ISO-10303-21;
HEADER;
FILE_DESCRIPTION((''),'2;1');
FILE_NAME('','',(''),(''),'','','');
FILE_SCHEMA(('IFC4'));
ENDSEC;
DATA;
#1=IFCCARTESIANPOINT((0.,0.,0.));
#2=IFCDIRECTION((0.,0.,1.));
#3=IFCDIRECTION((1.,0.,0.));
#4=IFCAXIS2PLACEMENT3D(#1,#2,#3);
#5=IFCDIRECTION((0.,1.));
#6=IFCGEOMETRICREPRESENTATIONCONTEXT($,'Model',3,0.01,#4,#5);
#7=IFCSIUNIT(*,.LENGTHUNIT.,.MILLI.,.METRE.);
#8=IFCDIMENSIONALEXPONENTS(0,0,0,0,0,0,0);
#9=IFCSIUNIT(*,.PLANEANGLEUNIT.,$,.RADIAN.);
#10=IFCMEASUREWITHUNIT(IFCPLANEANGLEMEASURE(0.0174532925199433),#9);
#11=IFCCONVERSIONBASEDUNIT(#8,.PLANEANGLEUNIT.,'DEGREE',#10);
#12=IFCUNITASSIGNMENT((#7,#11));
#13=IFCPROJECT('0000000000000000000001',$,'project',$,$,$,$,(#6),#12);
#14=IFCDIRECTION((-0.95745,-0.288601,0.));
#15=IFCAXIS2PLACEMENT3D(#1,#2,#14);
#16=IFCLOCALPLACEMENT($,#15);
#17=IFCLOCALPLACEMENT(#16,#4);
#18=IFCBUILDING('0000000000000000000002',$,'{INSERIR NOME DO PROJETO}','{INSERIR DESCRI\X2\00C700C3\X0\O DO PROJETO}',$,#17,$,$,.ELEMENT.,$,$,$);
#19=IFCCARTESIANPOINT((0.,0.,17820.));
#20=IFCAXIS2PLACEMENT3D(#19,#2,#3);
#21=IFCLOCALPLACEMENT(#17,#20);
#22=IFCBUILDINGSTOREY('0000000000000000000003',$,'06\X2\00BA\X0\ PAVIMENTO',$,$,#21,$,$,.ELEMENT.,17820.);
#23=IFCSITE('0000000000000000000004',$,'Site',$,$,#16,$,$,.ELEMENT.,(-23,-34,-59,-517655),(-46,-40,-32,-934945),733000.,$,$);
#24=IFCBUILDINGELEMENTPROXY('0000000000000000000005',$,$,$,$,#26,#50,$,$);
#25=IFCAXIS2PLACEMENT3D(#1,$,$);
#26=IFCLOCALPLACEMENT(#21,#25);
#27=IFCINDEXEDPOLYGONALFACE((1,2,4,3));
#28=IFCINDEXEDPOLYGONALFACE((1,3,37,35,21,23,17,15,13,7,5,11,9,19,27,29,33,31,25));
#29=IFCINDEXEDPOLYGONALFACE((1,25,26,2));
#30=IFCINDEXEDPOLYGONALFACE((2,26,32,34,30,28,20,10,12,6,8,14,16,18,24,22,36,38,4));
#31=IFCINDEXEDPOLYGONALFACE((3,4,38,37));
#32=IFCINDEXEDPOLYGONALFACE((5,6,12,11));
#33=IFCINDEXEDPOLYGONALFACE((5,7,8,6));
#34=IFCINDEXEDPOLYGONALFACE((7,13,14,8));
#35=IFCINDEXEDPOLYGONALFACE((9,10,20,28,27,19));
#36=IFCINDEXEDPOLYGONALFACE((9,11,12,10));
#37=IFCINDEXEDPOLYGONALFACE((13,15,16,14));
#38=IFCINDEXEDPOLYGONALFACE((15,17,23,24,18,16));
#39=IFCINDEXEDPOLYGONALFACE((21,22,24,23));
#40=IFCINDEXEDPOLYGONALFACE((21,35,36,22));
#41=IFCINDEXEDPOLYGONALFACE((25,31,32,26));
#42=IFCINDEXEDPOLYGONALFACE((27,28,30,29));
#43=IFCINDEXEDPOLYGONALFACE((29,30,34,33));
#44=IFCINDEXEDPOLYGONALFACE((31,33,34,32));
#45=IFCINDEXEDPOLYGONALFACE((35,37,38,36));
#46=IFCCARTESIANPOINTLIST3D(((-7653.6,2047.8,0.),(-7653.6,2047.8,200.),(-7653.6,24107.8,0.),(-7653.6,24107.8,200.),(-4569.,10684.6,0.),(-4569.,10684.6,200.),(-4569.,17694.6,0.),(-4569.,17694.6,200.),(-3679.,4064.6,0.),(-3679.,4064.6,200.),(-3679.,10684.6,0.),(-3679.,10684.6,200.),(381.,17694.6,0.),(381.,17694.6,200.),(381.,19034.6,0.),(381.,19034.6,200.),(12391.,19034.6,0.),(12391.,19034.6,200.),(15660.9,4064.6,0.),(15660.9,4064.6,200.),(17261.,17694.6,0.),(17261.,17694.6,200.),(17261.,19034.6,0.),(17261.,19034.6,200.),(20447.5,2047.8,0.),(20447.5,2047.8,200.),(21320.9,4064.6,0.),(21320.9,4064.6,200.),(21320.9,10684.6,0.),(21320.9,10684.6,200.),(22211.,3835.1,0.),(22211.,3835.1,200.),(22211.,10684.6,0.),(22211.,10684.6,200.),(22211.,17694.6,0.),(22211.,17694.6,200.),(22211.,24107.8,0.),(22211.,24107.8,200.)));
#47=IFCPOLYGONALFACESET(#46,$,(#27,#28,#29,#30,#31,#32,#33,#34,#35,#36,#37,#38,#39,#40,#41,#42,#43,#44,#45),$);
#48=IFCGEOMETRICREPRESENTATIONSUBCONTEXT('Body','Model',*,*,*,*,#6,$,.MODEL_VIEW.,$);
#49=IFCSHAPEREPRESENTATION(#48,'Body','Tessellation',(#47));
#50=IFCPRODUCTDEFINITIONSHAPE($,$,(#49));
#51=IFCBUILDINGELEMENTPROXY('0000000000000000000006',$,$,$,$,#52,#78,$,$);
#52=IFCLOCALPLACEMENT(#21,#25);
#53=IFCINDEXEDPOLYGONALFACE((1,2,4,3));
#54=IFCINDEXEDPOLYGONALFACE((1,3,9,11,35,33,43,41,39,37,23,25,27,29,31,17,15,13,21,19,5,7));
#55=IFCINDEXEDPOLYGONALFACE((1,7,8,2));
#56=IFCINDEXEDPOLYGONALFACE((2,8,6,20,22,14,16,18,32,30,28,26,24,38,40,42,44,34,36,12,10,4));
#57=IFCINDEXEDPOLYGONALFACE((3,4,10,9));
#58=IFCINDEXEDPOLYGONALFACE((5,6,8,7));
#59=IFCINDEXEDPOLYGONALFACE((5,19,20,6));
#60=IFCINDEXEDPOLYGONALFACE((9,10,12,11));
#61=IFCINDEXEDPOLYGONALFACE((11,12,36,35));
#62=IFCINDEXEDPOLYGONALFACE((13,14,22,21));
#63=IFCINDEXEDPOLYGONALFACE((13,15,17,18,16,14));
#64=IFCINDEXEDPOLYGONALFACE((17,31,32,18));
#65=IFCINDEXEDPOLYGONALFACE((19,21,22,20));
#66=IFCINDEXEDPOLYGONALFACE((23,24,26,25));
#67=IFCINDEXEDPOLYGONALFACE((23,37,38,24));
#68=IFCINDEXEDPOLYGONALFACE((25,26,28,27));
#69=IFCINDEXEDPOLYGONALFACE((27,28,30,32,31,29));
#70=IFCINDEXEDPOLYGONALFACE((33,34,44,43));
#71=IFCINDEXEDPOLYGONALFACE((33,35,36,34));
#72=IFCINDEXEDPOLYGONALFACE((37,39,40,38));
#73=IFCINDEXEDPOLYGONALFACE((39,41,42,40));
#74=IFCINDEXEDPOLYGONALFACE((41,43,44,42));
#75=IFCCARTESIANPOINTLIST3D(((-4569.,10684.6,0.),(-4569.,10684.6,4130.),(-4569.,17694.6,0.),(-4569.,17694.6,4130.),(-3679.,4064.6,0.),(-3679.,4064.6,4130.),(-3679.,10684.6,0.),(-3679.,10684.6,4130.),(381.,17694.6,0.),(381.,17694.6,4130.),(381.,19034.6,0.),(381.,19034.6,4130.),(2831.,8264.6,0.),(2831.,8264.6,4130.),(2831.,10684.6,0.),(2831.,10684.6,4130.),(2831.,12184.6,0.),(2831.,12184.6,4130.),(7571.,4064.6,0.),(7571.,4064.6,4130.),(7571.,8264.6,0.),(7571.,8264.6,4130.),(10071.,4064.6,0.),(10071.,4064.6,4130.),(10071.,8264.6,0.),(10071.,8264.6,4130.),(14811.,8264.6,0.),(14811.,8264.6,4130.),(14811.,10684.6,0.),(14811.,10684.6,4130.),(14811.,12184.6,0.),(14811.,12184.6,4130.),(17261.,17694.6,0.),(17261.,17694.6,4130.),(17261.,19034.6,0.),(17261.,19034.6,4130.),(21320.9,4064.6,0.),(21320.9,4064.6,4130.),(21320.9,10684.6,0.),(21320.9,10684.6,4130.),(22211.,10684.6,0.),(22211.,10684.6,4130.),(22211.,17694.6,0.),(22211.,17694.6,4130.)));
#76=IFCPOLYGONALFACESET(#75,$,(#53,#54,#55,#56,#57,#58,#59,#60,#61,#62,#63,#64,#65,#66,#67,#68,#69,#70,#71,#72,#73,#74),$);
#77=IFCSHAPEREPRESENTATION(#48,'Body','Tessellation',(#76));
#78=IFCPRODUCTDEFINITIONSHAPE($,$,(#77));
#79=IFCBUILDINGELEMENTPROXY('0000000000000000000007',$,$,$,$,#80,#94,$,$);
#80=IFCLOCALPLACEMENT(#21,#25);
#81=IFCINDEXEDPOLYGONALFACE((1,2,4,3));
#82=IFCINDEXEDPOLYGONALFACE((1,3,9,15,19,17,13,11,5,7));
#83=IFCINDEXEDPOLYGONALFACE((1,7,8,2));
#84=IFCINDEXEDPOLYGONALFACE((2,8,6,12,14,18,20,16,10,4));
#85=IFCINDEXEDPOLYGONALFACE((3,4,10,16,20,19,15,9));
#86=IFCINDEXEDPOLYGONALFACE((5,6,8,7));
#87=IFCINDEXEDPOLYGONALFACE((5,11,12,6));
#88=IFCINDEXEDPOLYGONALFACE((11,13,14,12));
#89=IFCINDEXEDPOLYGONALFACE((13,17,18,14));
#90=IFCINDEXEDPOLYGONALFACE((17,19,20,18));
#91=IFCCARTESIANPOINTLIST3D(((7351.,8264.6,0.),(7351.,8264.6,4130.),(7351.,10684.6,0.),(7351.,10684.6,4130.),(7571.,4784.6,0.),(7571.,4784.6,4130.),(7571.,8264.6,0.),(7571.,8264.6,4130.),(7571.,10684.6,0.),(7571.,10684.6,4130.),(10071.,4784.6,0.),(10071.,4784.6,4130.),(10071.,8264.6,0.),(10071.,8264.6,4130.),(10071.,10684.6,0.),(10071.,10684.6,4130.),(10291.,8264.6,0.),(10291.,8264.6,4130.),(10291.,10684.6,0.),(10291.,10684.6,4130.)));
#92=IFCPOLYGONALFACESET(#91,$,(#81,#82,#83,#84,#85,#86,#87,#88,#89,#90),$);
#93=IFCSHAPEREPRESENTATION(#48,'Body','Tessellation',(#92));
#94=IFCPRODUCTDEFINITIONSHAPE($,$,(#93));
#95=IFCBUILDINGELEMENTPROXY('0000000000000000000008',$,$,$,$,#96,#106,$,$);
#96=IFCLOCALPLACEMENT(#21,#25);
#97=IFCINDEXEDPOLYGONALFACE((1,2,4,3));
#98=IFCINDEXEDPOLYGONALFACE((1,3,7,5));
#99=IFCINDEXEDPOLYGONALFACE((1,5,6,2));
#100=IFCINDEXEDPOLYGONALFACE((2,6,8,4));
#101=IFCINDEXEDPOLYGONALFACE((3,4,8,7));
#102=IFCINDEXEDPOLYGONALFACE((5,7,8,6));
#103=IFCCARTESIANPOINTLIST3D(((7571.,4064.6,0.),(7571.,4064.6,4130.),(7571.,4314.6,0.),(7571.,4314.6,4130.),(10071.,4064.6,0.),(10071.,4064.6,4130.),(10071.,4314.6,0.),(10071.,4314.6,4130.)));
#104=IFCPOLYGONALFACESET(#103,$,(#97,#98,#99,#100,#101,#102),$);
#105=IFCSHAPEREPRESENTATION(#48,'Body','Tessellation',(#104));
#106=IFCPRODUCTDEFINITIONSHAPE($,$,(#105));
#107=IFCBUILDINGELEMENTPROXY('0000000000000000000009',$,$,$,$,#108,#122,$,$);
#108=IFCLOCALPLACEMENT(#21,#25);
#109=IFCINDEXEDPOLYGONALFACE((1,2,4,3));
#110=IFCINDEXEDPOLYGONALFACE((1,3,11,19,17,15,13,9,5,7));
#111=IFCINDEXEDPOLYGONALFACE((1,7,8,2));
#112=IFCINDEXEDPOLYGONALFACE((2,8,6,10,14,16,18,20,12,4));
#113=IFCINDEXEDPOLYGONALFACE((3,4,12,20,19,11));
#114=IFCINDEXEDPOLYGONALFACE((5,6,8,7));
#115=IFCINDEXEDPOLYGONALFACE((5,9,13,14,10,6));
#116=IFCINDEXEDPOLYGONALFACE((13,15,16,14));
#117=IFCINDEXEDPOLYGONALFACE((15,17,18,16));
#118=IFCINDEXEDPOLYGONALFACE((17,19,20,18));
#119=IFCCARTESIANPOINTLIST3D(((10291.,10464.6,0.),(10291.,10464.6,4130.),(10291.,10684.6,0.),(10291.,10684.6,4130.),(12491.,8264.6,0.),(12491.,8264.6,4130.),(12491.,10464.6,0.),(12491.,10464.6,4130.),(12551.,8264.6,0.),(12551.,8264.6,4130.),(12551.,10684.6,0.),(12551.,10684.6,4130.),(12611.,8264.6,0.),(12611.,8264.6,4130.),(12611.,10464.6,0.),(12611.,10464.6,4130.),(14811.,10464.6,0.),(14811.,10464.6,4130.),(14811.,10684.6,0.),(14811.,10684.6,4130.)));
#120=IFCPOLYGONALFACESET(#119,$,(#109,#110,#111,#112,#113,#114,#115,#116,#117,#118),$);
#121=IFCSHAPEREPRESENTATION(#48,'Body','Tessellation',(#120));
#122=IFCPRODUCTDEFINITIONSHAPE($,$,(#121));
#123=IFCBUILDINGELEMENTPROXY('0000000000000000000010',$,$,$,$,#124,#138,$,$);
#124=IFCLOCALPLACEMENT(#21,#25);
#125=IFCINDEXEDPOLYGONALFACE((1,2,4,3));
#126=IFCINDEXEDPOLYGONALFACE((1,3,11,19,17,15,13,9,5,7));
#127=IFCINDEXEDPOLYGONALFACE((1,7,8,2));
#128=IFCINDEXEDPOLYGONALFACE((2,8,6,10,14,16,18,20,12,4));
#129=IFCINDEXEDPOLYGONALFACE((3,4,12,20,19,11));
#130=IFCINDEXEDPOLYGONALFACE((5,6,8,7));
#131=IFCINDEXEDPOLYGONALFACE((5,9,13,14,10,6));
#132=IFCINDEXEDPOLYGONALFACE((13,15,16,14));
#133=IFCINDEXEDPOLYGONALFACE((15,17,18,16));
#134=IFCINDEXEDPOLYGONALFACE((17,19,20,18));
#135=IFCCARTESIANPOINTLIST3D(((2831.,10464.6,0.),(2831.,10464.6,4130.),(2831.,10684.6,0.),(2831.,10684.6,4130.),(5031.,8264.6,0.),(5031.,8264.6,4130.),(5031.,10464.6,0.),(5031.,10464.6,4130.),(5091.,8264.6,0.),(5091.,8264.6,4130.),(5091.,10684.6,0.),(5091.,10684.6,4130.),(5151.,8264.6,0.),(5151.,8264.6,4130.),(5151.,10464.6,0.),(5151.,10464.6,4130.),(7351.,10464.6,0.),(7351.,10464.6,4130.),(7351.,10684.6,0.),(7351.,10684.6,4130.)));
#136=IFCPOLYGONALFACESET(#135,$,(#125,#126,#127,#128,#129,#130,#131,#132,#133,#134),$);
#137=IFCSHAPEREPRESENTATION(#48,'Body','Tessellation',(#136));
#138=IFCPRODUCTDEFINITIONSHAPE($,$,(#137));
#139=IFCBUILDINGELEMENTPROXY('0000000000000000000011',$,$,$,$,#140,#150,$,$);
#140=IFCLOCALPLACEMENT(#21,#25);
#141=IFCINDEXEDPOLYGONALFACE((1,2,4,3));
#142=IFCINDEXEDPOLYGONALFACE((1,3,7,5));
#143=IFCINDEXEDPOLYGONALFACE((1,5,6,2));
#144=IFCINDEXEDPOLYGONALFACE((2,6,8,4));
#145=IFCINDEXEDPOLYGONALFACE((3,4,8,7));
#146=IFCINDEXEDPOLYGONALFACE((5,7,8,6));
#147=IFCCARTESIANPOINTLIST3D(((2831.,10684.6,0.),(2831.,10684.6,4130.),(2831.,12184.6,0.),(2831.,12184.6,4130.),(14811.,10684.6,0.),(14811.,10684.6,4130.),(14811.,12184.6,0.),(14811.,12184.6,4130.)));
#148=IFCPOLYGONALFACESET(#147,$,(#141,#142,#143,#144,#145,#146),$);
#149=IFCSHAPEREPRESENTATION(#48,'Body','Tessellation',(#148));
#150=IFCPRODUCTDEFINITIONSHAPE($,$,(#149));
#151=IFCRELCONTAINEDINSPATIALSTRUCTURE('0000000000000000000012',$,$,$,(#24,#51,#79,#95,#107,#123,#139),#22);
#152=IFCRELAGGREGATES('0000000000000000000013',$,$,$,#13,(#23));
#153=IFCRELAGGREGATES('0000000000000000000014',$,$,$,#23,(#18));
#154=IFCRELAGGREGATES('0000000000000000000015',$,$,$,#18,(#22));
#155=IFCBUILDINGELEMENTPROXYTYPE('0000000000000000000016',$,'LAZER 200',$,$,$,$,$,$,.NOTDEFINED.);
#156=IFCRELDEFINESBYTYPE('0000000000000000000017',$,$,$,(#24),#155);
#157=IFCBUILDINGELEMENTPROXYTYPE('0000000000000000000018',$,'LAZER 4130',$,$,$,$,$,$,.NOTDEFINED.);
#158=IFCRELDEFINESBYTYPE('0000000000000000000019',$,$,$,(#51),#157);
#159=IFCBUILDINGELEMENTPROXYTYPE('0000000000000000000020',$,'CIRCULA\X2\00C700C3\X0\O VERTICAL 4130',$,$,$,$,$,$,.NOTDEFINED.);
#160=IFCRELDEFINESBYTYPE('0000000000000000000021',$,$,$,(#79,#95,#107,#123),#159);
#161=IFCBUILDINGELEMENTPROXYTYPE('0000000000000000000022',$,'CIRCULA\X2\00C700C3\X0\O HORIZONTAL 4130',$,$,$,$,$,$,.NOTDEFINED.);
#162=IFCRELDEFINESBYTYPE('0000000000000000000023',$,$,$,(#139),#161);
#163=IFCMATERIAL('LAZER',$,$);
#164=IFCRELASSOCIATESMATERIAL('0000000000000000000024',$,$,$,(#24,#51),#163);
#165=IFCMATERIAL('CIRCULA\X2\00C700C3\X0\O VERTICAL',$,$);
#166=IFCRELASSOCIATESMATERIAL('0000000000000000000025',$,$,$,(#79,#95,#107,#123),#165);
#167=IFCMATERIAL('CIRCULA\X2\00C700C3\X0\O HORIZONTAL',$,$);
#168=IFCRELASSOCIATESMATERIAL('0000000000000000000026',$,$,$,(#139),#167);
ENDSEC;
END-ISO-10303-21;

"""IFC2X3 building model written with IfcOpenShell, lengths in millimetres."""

from ifc_helpers import new_model, entity, si_unit, converted_unit, direction, frame, origin_with_axes, place, context, subcontext, project, spatial, polyline, outline, extrude, material, type_object, element, save


model = new_model("IFC2X3")

# Units and contexts
model_context = context("Model", 3, precision=0.01, world=origin_with_axes(), true_north=direction((0.0, 1.0)))
body_context = subcontext(model_context, "Body", "Model", "MODEL_VIEW")
ifc_project = project(units=[si_unit("LENGTHUNIT", "METRE", prefix="MILLI"), converted_unit("PLANEANGLEUNIT", "DEGREE", entity("IfcPlaneAngleMeasure", 0.0174532925199433), si_unit("PLANEANGLEUNIT", "RADIAN"), dimensions=[0, 0, 0, 0, 0, 0, 0])], contexts=[model_context])

# Site, building, storey
site_placement = place(None, frame((0.0, 0.0, 0.0), z_axis=(0.0, 0.0, 1.0), x_axis=(-0.95745, -0.288601, 0.0)))
site = spatial("IfcSite", under=ifc_project, at=site_placement, Name="Site", CompositionType="ELEMENT", RefLatitude=(-23, -34, -59, -517655), RefLongitude=(-46, -40, -32, -934945), RefElevation=733000.0)
building_placement = place(site_placement, origin_with_axes())
building = spatial("IfcBuilding", under=site, at=building_placement, Name="{INSERIR NOME DO PROJETO}", Description="{INSERIR DESCRIÇÃO DO PROJETO}", CompositionType="ELEMENT")
storey_placement = place(building_placement, frame((0.0, 0.0, 17820.0), z_axis=(0.0, 0.0, 1.0), x_axis=(1.0, 0.0, 0.0)))
storey = spatial("IfcBuildingStorey", under=building, at=storey_placement, Name="06º PAVIMENTO", CompositionType="ELEMENT", Elevation=17820.0)

# Building element proxies
ifc_material_1 = material(Name="LAZER")
building_element_proxy_type_1 = type_object("IfcBuildingElementProxyType", Name="LAZER 200", PredefinedType="NOTDEFINED")
proxy_1_placement = place(storey_placement, frame((-7653.6, 24107.8, 0.0), z_axis=(0.0, 0.0, 1.0), x_axis=(1.0, 0.0, 0.0)))
element("IfcBuildingElementProxy", 1, at=proxy_1_placement, inside=storey, type_object=building_element_proxy_type_1, material=ifc_material_1, context=body_context, shape_type="SweptSolid", body=[
    extrude(outline(polyline([(0.0, 0.0), (0.0, -22060.0), (28101.1, -22060.0), (29864.6, -20272.6), (29864.6, -13423.2), (28974.6, -13423.2), (28974.6, -20043.2), (23314.5, -20043.2), (3974.6, -20043.2), (3974.6, -13423.2), (3084.6, -13423.2), (3084.6, -6413.2), (8034.6, -6413.2), (8034.6, -5073.2), (20044.6, -5073.2), (24914.6, -5073.2), (24914.6, -6413.2), (29864.6, -6413.2), (29864.6, 0.0), (0.0, 0.0)])), origin_with_axes(), (0.0, 0.0, 1.0), 200.0),
])
building_element_proxy_type_2 = type_object("IfcBuildingElementProxyType", Name="LAZER 4130", PredefinedType="NOTDEFINED")
proxy_2_placement = place(storey_placement, frame((-4569.0, 10684.6, 0.0), z_axis=(0.0, 0.0, 1.0), x_axis=(1.0, 0.0, 0.0)))
element("IfcBuildingElementProxy", 2, at=proxy_2_placement, inside=storey, type_object=building_element_proxy_type_2, material=ifc_material_1, context=body_context, shape_type="SweptSolid", body=[
    extrude(outline(polyline([(0.0, 0.0), (890.0, 0.0), (890.0, -6620.0), (12140.0, -6620.0), (12140.0, -2420.0), (7400.0, -2420.0), (7400.0, 0.0), (7400.0, 1500.0), (19380.0, 1500.0), (19380.0, 0.0), (19380.0, -2420.0), (14640.0, -2420.0), (14640.0, -6620.0), (25890.0, -6620.0), (25890.0, 0.0), (26780.0, 0.0), (26780.0, 7010.0), (21830.0, 7010.0), (21830.0, 8350.0), (4950.0, 8350.0), (4950.0, 7010.0), (0.0, 7010.0), (0.0, 0.0)])), origin_with_axes(), (0.0, 0.0, 1.0), 4130.0),
])
ifc_material_2 = material(Name="CIRCULAÇÃO VERTICAL")
building_element_proxy_type_3 = type_object("IfcBuildingElementProxyType", Name="CIRCULAÇÃO VERTICAL 4130", PredefinedType="NOTDEFINED")
proxy_3_placement = place(storey_placement, frame((7351.0, 10684.6, 0.0), z_axis=(0.0, 0.0, 1.0), x_axis=(1.0, 0.0, 0.0)))
element("IfcBuildingElementProxy", 3, at=proxy_3_placement, inside=storey, type_object=building_element_proxy_type_3, material=ifc_material_2, context=body_context, shape_type="SweptSolid", body=[
    extrude(outline(polyline([(0.0, 0.0), (0.0, -2420.0), (220.0, -2420.0), (220.0, -5900.0), (2720.0, -5900.0), (2720.0, -2420.0), (2940.0, -2420.0), (2940.0, 0.0), (2720.0, 0.0), (220.0, 0.0), (0.0, 0.0)])), origin_with_axes(), (0.0, 0.0, 1.0), 4130.0),
])
proxy_4_placement = place(storey_placement, frame((7571.0, 4064.6, 0.0), z_axis=(0.0, 0.0, 1.0), x_axis=(1.0, 0.0, 0.0)))
element("IfcBuildingElementProxy", 4, at=proxy_4_placement, inside=storey, type_object=building_element_proxy_type_3, material=ifc_material_2, context=body_context, shape_type="SweptSolid", body=[
    extrude(outline(polyline([(0.0, 0.0), (2500.0, 0.0), (2500.0, 250.0), (0.0, 250.0), (0.0, 0.0)])), origin_with_axes(), (0.0, 0.0, 1.0), 4130.0),
])
proxy_5_placement = place(storey_placement, frame((10291.0, 10684.6, 0.0), z_axis=(0.0, 0.0, 1.0), x_axis=(1.0, 0.0, 0.0)))
element("IfcBuildingElementProxy", 5, at=proxy_5_placement, inside=storey, type_object=building_element_proxy_type_3, material=ifc_material_2, context=body_context, shape_type="SweptSolid", body=[
    extrude(outline(polyline([(0.0, 0.0), (0.0, -220.0), (2200.0, -220.0), (2200.0, -2420.0), (2260.0, -2420.0), (2320.0, -2420.0), (2320.0, -220.0), (4520.0, -220.0), (4520.0, 0.0), (2260.0, 0.0), (0.0, 0.0)])), origin_with_axes(), (0.0, 0.0, 1.0), 4130.0),
])
proxy_6_placement = place(storey_placement, frame((5091.0, 10684.6, 0.0), z_axis=(0.0, 0.0, 1.0), x_axis=(1.0, 0.0, 0.0)))
element("IfcBuildingElementProxy", 6, at=proxy_6_placement, inside=storey, type_object=building_element_proxy_type_3, material=ifc_material_2, context=body_context, shape_type="SweptSolid", body=[
    extrude(outline(polyline([(0.0, 0.0), (-2260.0, 0.0), (-2260.0, -220.0), (-60.0, -220.0), (-60.0, -2420.0), (0.0, -2420.0), (60.0, -2420.0), (60.0, -220.0), (2260.0, -220.0), (2260.0, 0.0), (0.0, 0.0)])), origin_with_axes(), (0.0, 0.0, 1.0), 4130.0),
])
ifc_material_3 = material(Name="CIRCULAÇÃO HORIZONTAL")
building_element_proxy_type_4 = type_object("IfcBuildingElementProxyType", Name="CIRCULAÇÃO HORIZONTAL 4130", PredefinedType="NOTDEFINED")
proxy_7_placement = place(storey_placement, frame((2831.0, 10684.6, 0.0), z_axis=(0.0, 0.0, 1.0), x_axis=(1.0, 0.0, 0.0)))
element("IfcBuildingElementProxy", 7, at=proxy_7_placement, inside=storey, type_object=building_element_proxy_type_4, material=ifc_material_3, context=body_context, shape_type="SweptSolid", body=[
    extrude(outline(polyline([(0.0, 0.0), (11980.0, 0.0), (11980.0, 1500.0), (0.0, 1500.0), (0.0, 0.0)])), origin_with_axes(), (0.0, 0.0, 1.0), 4130.0),
])

save(model, "model.ifc")
